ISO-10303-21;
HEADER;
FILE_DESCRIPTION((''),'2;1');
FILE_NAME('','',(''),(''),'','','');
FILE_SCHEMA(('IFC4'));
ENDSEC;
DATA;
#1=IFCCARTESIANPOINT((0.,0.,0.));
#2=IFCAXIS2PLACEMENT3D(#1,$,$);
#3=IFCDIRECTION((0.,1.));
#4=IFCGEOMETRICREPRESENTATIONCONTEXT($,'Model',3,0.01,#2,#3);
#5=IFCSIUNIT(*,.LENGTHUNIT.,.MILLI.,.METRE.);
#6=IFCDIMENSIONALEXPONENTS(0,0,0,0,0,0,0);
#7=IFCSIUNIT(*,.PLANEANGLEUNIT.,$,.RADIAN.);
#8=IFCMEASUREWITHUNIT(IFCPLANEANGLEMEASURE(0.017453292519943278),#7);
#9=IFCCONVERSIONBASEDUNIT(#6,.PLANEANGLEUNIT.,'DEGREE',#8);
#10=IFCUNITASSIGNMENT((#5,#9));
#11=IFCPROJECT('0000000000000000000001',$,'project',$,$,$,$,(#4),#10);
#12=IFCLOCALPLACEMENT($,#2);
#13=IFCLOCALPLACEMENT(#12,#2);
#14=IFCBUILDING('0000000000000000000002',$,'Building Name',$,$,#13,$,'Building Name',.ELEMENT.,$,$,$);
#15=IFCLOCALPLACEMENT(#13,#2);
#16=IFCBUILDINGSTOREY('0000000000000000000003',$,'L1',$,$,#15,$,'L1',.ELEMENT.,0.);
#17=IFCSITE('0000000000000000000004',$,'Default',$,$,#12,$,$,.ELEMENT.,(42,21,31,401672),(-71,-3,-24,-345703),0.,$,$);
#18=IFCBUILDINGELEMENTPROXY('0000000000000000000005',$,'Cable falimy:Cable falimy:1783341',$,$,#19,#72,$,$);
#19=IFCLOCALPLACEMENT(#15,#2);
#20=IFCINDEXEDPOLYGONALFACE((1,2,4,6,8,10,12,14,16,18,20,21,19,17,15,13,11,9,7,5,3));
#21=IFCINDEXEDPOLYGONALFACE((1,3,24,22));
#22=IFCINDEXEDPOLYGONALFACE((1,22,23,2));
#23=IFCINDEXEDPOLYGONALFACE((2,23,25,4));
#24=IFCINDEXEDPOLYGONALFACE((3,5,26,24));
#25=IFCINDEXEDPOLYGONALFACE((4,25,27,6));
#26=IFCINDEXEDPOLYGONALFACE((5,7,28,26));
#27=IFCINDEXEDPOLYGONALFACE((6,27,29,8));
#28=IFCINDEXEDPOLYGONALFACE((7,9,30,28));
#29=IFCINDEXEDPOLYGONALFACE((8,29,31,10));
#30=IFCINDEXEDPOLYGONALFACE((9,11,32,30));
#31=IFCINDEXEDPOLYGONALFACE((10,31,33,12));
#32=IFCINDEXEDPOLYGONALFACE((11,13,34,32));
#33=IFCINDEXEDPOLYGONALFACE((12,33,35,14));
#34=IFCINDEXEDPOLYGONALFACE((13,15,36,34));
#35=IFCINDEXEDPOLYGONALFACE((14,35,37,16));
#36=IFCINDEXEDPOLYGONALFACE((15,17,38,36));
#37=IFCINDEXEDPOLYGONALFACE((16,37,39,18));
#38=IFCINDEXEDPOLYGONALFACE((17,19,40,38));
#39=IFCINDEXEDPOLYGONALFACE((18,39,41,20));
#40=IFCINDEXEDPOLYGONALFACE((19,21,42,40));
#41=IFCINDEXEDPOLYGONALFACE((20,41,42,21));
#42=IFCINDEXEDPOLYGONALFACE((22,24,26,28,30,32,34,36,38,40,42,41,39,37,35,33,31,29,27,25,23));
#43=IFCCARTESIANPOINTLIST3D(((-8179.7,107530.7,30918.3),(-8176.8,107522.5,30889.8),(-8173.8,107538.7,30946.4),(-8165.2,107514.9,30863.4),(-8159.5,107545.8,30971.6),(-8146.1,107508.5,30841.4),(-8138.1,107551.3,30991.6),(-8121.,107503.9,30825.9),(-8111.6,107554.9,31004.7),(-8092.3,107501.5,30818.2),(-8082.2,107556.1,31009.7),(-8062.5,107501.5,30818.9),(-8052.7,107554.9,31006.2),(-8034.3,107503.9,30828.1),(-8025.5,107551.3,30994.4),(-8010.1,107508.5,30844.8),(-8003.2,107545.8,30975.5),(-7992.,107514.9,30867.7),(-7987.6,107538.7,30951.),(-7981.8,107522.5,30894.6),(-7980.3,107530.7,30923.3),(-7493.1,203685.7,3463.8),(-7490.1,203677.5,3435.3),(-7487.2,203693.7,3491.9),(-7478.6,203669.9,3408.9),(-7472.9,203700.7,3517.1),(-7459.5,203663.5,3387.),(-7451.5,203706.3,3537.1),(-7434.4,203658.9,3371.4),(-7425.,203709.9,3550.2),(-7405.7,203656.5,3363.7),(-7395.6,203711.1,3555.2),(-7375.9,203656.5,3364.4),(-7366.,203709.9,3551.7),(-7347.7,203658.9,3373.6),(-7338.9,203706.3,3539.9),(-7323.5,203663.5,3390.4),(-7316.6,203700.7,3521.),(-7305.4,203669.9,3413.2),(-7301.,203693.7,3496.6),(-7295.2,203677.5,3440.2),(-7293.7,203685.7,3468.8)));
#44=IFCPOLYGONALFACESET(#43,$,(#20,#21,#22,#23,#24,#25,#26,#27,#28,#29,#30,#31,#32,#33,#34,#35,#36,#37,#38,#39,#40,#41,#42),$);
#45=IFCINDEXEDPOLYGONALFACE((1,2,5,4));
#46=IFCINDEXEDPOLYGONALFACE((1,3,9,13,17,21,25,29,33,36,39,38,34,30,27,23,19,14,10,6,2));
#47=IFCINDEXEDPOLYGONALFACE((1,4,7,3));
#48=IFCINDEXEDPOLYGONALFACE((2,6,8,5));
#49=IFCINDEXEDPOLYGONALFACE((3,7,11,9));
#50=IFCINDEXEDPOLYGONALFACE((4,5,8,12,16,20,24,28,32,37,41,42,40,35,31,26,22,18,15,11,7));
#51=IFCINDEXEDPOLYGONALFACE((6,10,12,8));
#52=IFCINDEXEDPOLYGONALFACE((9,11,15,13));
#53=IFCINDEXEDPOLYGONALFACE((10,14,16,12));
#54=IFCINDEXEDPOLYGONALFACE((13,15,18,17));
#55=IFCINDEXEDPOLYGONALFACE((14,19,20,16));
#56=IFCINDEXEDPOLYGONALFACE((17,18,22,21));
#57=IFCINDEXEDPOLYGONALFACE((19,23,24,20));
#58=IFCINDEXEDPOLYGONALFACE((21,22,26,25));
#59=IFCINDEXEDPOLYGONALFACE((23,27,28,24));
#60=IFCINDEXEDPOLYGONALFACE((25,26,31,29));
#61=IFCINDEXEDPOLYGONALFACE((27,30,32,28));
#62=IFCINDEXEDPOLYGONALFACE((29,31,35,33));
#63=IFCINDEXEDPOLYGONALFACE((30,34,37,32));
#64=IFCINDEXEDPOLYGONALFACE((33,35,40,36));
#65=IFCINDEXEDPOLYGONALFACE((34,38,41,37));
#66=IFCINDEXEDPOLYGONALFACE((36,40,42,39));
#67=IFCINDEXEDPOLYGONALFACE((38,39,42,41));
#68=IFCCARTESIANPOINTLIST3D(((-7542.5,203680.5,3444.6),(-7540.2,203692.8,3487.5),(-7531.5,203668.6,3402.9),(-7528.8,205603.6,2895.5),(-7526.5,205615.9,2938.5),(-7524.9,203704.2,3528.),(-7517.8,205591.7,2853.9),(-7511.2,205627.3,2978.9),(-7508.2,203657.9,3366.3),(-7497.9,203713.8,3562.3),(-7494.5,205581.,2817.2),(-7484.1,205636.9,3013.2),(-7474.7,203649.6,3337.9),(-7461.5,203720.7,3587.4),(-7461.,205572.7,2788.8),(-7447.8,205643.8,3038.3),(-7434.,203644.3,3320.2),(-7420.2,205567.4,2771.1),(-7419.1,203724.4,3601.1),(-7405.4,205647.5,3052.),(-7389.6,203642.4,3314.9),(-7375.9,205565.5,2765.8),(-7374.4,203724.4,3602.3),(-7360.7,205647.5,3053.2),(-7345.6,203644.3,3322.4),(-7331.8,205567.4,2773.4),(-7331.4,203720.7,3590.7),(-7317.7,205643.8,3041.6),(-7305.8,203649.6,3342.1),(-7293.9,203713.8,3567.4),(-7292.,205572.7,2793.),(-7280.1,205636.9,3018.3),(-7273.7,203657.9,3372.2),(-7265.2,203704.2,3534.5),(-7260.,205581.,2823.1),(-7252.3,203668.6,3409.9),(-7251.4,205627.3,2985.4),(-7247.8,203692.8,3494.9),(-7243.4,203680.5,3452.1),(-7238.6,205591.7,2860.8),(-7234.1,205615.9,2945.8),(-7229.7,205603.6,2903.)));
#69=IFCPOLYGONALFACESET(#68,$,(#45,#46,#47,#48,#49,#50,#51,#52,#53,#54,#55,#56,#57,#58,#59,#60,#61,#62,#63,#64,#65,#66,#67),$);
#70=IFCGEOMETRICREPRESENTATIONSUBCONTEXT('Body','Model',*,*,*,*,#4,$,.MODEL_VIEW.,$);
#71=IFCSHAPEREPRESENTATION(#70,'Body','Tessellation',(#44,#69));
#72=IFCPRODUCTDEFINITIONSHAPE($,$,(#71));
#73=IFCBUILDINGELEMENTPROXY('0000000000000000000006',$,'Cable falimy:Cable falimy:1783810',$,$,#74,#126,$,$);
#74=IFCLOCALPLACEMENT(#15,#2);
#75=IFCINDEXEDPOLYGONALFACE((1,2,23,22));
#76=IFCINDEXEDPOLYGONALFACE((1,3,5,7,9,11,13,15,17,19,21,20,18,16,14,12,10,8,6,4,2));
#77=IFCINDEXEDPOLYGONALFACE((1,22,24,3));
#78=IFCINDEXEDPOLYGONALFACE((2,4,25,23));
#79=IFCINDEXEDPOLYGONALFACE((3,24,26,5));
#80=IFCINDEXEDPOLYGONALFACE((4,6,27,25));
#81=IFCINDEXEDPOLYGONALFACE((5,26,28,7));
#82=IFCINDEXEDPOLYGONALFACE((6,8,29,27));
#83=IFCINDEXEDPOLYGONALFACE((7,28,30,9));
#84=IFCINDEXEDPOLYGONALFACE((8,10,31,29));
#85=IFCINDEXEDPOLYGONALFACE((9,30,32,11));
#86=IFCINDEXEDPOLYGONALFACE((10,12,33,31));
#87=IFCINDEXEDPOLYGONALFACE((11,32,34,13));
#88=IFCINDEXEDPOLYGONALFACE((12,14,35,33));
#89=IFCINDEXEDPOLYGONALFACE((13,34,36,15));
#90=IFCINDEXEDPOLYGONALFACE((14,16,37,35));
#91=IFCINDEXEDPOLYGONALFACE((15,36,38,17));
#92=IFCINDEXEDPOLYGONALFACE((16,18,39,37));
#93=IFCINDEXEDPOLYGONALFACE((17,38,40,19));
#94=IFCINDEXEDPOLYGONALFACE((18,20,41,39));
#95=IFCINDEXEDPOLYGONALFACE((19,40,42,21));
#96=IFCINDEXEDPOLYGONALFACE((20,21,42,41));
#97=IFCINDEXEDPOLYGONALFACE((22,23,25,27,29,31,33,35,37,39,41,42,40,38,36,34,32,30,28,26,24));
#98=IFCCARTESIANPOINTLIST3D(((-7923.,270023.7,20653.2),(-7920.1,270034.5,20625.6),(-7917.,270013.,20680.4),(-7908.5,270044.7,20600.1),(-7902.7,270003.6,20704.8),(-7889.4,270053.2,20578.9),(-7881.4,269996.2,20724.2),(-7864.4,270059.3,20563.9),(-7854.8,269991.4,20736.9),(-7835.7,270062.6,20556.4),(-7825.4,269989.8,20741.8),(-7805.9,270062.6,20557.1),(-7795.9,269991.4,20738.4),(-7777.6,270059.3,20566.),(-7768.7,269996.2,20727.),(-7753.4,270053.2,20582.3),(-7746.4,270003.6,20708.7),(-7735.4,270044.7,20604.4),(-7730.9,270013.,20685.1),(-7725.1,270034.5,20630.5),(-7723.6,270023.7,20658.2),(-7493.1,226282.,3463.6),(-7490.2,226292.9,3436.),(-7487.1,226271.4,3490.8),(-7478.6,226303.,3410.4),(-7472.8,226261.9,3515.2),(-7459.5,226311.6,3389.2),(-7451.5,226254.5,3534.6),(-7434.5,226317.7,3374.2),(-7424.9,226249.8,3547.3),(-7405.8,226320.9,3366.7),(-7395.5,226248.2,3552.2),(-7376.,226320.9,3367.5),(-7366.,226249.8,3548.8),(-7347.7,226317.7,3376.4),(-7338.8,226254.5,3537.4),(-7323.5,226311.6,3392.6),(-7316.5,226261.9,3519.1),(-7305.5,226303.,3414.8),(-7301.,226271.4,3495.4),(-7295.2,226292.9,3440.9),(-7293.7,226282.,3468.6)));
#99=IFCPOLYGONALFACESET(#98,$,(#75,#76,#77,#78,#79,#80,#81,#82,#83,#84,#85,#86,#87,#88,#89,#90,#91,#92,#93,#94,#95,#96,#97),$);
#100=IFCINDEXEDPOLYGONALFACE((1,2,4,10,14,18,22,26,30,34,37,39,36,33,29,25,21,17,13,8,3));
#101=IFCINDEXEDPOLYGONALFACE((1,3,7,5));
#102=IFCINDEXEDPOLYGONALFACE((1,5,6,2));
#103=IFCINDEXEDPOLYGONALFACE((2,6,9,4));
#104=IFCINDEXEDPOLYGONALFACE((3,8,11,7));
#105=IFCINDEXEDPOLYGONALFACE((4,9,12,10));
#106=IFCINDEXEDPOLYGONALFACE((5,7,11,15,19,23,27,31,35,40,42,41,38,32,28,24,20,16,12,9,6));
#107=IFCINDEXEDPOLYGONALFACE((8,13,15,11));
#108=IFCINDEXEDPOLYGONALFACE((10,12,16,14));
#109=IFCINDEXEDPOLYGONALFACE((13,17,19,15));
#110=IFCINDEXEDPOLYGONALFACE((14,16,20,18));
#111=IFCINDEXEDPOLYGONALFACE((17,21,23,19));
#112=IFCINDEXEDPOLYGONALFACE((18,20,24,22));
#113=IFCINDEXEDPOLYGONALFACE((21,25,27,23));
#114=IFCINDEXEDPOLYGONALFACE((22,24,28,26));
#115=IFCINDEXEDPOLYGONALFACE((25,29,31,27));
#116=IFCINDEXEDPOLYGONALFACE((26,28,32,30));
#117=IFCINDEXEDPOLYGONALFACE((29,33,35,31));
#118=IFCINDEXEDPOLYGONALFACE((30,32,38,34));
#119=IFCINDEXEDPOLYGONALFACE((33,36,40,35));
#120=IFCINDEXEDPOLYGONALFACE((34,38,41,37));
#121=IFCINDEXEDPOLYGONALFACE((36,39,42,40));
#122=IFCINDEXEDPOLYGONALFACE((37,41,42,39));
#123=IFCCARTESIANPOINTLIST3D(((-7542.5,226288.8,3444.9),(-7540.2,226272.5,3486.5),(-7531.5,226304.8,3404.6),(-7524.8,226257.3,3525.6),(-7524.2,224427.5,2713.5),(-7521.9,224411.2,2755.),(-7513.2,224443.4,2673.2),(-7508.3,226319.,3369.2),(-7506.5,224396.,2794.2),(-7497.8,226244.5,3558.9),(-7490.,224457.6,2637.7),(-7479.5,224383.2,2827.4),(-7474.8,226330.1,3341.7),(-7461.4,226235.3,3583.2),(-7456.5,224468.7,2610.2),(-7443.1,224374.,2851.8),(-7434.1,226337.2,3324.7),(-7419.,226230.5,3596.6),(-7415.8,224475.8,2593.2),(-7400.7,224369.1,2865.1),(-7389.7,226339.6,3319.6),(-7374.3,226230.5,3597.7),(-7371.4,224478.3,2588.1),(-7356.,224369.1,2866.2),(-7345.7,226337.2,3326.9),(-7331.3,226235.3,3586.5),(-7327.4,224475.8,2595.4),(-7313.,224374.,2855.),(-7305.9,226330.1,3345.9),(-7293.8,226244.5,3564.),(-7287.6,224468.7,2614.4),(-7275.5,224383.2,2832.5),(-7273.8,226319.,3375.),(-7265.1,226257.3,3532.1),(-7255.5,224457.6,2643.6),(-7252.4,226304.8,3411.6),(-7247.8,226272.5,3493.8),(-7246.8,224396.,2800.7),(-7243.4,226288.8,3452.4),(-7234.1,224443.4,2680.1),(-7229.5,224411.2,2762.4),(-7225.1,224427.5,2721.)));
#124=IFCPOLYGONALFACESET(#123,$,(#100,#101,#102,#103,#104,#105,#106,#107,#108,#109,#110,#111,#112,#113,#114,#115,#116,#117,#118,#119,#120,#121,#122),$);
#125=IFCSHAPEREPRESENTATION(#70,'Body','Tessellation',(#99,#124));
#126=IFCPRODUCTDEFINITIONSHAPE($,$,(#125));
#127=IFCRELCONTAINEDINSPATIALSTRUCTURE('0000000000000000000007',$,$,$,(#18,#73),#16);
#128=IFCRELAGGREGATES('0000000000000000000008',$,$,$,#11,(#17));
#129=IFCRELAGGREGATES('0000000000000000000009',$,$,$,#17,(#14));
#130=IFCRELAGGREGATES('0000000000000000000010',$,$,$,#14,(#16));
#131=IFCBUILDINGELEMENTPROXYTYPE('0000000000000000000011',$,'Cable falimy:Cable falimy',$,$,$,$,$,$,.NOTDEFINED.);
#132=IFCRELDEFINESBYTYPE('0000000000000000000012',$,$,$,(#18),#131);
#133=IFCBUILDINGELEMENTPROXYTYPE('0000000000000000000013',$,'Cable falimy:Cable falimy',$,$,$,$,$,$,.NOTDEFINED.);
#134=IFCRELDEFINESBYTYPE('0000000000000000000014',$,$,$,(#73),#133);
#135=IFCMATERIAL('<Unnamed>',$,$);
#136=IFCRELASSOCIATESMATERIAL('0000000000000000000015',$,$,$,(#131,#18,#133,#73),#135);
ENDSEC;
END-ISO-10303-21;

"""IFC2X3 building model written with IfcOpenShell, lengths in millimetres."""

from ifc_helpers import new_model, entity, si_unit, converted_unit, direction, frame, frame_2d, origin, place, context, subcontext, project, spatial, circle, extrude, source, transform, mapped, material, type_object, type_shapes, element, save


model = new_model("IFC2X3")

# Units and contexts
model_context = context("Model", 3, precision=0.01, world=origin(), true_north=direction((0.0, 1.0)))
body_context = subcontext(model_context, "Body", "Model", "MODEL_VIEW")
ifc_project = project(units=[si_unit("LENGTHUNIT", "METRE", prefix="MILLI"), converted_unit("PLANEANGLEUNIT", "DEGREE", entity("IfcPlaneAngleMeasure", 0.017453292519943278), si_unit("PLANEANGLEUNIT", "RADIAN"), dimensions=[0, 0, 0, 0, 0, 0, 0])], contexts=[model_context])

# Site, building, storey
site_placement = place(None, origin())
site = spatial("IfcSite", under=ifc_project, at=site_placement, Name="Default", CompositionType="ELEMENT", RefLatitude=(42, 21, 31, 401672), RefLongitude=(-71, -3, -24, -345703), RefElevation=0.0)
building_placement = place(site_placement, origin())
building = spatial("IfcBuilding", under=site, at=building_placement, Name="Building Name", LongName="Building Name", CompositionType="ELEMENT")
storey_placement = place(building_placement, origin())
storey = spatial("IfcBuildingStorey", under=building, at=storey_placement, Name="L1", LongName="L1", CompositionType="ELEMENT", Elevation=0.0)

# Shared definitions
ifc_material = material(Name="<Unnamed>")

# Building element proxies
building_element_proxy_type_1 = type_object("IfcBuildingElementProxyType", Name="Cable falimy:Cable falimy", PredefinedType="NOTDEFINED", material=ifc_material)
shared_shape_1 = source(origin(), body_context, "Body", "SweptSolid", [
    extrude(circle(Radius=100.0, at=frame_2d((0.0, 0.0), x_axis=(1.0, 0.0))), frame((0.0, 0.0, 0.0), z_axis=(0.96155, 0.0, 0.274631), x_axis=(-0.274631, 0.0, 0.96155)), (0.0, 0.0, 1.0), 100000.0),
    extrude(circle(Radius=150.0, at=frame_2d((0.0, 0.0), x_axis=(1.0, 0.0))), frame((-1923.1, 0.0, -549.3), z_axis=(0.96155, 0.0, 0.274631), x_axis=(0.274631, 0.0, -0.96155)), (0.0, 0.0, 1.0), 2000.0),
])
type_shapes(building_element_proxy_type_1, [shared_shape_1])
proxy_1_placement = place(storey_placement, frame((-7393.2, 203683.6, 3459.1), z_axis=(-0.025001, 0.0, 0.999687), x_axis=(0.0, -1.0, 0.0)))
element("IfcBuildingElementProxy", 1, at=proxy_1_placement, inside=storey, type_object=building_element_proxy_type_1, material=ifc_material, Name="Cable falimy:Cable falimy:1783341", context=body_context, shape_type="MappedRepresentation", body=[
    mapped(shared_shape_1, transform((0.0, 0.0, 0.0), scale=1.0)),
])
building_element_proxy_type_2 = type_object("IfcBuildingElementProxyType", Name="Cable falimy:Cable falimy", PredefinedType="NOTDEFINED", material=ifc_material)
shared_shape_2 = source(origin(), body_context, "Body", "SweptSolid", [
    extrude(circle(Radius=100.0, at=frame_2d((0.0, 0.0), x_axis=(1.0, 0.0))), frame((0.0, 0.0, 0.0), z_axis=(0.930673, 0.0, 0.365852), x_axis=(-0.365852, 0.0, 0.930673)), (0.0, 0.0, 1.0), 47000.0),
    extrude(circle(Radius=150.0, at=frame_2d((0.0, 0.0), x_axis=(1.0, 0.0))), frame((-1861.3, 0.0, -731.7), z_axis=(0.930673, 0.0, 0.365852), x_axis=(0.365852, 0.0, -0.930673)), (0.0, 0.0, 1.0), 2000.0),
])
type_shapes(building_element_proxy_type_2, [shared_shape_2])
proxy_2_placement = place(storey_placement, frame((-7393.2, 226284.7, 3459.1), z_axis=(-0.025001, 0.0, 0.999687), x_axis=(0.0, 1.0, 0.0)))
element("IfcBuildingElementProxy", 2, at=proxy_2_placement, inside=storey, type_object=building_element_proxy_type_2, material=ifc_material, Name="Cable falimy:Cable falimy:1783810", context=body_context, shape_type="MappedRepresentation", body=[
    mapped(shared_shape_2, transform((0.0, 0.0, 0.0), scale=1.0)),
])

save(model, "model.ifc")
